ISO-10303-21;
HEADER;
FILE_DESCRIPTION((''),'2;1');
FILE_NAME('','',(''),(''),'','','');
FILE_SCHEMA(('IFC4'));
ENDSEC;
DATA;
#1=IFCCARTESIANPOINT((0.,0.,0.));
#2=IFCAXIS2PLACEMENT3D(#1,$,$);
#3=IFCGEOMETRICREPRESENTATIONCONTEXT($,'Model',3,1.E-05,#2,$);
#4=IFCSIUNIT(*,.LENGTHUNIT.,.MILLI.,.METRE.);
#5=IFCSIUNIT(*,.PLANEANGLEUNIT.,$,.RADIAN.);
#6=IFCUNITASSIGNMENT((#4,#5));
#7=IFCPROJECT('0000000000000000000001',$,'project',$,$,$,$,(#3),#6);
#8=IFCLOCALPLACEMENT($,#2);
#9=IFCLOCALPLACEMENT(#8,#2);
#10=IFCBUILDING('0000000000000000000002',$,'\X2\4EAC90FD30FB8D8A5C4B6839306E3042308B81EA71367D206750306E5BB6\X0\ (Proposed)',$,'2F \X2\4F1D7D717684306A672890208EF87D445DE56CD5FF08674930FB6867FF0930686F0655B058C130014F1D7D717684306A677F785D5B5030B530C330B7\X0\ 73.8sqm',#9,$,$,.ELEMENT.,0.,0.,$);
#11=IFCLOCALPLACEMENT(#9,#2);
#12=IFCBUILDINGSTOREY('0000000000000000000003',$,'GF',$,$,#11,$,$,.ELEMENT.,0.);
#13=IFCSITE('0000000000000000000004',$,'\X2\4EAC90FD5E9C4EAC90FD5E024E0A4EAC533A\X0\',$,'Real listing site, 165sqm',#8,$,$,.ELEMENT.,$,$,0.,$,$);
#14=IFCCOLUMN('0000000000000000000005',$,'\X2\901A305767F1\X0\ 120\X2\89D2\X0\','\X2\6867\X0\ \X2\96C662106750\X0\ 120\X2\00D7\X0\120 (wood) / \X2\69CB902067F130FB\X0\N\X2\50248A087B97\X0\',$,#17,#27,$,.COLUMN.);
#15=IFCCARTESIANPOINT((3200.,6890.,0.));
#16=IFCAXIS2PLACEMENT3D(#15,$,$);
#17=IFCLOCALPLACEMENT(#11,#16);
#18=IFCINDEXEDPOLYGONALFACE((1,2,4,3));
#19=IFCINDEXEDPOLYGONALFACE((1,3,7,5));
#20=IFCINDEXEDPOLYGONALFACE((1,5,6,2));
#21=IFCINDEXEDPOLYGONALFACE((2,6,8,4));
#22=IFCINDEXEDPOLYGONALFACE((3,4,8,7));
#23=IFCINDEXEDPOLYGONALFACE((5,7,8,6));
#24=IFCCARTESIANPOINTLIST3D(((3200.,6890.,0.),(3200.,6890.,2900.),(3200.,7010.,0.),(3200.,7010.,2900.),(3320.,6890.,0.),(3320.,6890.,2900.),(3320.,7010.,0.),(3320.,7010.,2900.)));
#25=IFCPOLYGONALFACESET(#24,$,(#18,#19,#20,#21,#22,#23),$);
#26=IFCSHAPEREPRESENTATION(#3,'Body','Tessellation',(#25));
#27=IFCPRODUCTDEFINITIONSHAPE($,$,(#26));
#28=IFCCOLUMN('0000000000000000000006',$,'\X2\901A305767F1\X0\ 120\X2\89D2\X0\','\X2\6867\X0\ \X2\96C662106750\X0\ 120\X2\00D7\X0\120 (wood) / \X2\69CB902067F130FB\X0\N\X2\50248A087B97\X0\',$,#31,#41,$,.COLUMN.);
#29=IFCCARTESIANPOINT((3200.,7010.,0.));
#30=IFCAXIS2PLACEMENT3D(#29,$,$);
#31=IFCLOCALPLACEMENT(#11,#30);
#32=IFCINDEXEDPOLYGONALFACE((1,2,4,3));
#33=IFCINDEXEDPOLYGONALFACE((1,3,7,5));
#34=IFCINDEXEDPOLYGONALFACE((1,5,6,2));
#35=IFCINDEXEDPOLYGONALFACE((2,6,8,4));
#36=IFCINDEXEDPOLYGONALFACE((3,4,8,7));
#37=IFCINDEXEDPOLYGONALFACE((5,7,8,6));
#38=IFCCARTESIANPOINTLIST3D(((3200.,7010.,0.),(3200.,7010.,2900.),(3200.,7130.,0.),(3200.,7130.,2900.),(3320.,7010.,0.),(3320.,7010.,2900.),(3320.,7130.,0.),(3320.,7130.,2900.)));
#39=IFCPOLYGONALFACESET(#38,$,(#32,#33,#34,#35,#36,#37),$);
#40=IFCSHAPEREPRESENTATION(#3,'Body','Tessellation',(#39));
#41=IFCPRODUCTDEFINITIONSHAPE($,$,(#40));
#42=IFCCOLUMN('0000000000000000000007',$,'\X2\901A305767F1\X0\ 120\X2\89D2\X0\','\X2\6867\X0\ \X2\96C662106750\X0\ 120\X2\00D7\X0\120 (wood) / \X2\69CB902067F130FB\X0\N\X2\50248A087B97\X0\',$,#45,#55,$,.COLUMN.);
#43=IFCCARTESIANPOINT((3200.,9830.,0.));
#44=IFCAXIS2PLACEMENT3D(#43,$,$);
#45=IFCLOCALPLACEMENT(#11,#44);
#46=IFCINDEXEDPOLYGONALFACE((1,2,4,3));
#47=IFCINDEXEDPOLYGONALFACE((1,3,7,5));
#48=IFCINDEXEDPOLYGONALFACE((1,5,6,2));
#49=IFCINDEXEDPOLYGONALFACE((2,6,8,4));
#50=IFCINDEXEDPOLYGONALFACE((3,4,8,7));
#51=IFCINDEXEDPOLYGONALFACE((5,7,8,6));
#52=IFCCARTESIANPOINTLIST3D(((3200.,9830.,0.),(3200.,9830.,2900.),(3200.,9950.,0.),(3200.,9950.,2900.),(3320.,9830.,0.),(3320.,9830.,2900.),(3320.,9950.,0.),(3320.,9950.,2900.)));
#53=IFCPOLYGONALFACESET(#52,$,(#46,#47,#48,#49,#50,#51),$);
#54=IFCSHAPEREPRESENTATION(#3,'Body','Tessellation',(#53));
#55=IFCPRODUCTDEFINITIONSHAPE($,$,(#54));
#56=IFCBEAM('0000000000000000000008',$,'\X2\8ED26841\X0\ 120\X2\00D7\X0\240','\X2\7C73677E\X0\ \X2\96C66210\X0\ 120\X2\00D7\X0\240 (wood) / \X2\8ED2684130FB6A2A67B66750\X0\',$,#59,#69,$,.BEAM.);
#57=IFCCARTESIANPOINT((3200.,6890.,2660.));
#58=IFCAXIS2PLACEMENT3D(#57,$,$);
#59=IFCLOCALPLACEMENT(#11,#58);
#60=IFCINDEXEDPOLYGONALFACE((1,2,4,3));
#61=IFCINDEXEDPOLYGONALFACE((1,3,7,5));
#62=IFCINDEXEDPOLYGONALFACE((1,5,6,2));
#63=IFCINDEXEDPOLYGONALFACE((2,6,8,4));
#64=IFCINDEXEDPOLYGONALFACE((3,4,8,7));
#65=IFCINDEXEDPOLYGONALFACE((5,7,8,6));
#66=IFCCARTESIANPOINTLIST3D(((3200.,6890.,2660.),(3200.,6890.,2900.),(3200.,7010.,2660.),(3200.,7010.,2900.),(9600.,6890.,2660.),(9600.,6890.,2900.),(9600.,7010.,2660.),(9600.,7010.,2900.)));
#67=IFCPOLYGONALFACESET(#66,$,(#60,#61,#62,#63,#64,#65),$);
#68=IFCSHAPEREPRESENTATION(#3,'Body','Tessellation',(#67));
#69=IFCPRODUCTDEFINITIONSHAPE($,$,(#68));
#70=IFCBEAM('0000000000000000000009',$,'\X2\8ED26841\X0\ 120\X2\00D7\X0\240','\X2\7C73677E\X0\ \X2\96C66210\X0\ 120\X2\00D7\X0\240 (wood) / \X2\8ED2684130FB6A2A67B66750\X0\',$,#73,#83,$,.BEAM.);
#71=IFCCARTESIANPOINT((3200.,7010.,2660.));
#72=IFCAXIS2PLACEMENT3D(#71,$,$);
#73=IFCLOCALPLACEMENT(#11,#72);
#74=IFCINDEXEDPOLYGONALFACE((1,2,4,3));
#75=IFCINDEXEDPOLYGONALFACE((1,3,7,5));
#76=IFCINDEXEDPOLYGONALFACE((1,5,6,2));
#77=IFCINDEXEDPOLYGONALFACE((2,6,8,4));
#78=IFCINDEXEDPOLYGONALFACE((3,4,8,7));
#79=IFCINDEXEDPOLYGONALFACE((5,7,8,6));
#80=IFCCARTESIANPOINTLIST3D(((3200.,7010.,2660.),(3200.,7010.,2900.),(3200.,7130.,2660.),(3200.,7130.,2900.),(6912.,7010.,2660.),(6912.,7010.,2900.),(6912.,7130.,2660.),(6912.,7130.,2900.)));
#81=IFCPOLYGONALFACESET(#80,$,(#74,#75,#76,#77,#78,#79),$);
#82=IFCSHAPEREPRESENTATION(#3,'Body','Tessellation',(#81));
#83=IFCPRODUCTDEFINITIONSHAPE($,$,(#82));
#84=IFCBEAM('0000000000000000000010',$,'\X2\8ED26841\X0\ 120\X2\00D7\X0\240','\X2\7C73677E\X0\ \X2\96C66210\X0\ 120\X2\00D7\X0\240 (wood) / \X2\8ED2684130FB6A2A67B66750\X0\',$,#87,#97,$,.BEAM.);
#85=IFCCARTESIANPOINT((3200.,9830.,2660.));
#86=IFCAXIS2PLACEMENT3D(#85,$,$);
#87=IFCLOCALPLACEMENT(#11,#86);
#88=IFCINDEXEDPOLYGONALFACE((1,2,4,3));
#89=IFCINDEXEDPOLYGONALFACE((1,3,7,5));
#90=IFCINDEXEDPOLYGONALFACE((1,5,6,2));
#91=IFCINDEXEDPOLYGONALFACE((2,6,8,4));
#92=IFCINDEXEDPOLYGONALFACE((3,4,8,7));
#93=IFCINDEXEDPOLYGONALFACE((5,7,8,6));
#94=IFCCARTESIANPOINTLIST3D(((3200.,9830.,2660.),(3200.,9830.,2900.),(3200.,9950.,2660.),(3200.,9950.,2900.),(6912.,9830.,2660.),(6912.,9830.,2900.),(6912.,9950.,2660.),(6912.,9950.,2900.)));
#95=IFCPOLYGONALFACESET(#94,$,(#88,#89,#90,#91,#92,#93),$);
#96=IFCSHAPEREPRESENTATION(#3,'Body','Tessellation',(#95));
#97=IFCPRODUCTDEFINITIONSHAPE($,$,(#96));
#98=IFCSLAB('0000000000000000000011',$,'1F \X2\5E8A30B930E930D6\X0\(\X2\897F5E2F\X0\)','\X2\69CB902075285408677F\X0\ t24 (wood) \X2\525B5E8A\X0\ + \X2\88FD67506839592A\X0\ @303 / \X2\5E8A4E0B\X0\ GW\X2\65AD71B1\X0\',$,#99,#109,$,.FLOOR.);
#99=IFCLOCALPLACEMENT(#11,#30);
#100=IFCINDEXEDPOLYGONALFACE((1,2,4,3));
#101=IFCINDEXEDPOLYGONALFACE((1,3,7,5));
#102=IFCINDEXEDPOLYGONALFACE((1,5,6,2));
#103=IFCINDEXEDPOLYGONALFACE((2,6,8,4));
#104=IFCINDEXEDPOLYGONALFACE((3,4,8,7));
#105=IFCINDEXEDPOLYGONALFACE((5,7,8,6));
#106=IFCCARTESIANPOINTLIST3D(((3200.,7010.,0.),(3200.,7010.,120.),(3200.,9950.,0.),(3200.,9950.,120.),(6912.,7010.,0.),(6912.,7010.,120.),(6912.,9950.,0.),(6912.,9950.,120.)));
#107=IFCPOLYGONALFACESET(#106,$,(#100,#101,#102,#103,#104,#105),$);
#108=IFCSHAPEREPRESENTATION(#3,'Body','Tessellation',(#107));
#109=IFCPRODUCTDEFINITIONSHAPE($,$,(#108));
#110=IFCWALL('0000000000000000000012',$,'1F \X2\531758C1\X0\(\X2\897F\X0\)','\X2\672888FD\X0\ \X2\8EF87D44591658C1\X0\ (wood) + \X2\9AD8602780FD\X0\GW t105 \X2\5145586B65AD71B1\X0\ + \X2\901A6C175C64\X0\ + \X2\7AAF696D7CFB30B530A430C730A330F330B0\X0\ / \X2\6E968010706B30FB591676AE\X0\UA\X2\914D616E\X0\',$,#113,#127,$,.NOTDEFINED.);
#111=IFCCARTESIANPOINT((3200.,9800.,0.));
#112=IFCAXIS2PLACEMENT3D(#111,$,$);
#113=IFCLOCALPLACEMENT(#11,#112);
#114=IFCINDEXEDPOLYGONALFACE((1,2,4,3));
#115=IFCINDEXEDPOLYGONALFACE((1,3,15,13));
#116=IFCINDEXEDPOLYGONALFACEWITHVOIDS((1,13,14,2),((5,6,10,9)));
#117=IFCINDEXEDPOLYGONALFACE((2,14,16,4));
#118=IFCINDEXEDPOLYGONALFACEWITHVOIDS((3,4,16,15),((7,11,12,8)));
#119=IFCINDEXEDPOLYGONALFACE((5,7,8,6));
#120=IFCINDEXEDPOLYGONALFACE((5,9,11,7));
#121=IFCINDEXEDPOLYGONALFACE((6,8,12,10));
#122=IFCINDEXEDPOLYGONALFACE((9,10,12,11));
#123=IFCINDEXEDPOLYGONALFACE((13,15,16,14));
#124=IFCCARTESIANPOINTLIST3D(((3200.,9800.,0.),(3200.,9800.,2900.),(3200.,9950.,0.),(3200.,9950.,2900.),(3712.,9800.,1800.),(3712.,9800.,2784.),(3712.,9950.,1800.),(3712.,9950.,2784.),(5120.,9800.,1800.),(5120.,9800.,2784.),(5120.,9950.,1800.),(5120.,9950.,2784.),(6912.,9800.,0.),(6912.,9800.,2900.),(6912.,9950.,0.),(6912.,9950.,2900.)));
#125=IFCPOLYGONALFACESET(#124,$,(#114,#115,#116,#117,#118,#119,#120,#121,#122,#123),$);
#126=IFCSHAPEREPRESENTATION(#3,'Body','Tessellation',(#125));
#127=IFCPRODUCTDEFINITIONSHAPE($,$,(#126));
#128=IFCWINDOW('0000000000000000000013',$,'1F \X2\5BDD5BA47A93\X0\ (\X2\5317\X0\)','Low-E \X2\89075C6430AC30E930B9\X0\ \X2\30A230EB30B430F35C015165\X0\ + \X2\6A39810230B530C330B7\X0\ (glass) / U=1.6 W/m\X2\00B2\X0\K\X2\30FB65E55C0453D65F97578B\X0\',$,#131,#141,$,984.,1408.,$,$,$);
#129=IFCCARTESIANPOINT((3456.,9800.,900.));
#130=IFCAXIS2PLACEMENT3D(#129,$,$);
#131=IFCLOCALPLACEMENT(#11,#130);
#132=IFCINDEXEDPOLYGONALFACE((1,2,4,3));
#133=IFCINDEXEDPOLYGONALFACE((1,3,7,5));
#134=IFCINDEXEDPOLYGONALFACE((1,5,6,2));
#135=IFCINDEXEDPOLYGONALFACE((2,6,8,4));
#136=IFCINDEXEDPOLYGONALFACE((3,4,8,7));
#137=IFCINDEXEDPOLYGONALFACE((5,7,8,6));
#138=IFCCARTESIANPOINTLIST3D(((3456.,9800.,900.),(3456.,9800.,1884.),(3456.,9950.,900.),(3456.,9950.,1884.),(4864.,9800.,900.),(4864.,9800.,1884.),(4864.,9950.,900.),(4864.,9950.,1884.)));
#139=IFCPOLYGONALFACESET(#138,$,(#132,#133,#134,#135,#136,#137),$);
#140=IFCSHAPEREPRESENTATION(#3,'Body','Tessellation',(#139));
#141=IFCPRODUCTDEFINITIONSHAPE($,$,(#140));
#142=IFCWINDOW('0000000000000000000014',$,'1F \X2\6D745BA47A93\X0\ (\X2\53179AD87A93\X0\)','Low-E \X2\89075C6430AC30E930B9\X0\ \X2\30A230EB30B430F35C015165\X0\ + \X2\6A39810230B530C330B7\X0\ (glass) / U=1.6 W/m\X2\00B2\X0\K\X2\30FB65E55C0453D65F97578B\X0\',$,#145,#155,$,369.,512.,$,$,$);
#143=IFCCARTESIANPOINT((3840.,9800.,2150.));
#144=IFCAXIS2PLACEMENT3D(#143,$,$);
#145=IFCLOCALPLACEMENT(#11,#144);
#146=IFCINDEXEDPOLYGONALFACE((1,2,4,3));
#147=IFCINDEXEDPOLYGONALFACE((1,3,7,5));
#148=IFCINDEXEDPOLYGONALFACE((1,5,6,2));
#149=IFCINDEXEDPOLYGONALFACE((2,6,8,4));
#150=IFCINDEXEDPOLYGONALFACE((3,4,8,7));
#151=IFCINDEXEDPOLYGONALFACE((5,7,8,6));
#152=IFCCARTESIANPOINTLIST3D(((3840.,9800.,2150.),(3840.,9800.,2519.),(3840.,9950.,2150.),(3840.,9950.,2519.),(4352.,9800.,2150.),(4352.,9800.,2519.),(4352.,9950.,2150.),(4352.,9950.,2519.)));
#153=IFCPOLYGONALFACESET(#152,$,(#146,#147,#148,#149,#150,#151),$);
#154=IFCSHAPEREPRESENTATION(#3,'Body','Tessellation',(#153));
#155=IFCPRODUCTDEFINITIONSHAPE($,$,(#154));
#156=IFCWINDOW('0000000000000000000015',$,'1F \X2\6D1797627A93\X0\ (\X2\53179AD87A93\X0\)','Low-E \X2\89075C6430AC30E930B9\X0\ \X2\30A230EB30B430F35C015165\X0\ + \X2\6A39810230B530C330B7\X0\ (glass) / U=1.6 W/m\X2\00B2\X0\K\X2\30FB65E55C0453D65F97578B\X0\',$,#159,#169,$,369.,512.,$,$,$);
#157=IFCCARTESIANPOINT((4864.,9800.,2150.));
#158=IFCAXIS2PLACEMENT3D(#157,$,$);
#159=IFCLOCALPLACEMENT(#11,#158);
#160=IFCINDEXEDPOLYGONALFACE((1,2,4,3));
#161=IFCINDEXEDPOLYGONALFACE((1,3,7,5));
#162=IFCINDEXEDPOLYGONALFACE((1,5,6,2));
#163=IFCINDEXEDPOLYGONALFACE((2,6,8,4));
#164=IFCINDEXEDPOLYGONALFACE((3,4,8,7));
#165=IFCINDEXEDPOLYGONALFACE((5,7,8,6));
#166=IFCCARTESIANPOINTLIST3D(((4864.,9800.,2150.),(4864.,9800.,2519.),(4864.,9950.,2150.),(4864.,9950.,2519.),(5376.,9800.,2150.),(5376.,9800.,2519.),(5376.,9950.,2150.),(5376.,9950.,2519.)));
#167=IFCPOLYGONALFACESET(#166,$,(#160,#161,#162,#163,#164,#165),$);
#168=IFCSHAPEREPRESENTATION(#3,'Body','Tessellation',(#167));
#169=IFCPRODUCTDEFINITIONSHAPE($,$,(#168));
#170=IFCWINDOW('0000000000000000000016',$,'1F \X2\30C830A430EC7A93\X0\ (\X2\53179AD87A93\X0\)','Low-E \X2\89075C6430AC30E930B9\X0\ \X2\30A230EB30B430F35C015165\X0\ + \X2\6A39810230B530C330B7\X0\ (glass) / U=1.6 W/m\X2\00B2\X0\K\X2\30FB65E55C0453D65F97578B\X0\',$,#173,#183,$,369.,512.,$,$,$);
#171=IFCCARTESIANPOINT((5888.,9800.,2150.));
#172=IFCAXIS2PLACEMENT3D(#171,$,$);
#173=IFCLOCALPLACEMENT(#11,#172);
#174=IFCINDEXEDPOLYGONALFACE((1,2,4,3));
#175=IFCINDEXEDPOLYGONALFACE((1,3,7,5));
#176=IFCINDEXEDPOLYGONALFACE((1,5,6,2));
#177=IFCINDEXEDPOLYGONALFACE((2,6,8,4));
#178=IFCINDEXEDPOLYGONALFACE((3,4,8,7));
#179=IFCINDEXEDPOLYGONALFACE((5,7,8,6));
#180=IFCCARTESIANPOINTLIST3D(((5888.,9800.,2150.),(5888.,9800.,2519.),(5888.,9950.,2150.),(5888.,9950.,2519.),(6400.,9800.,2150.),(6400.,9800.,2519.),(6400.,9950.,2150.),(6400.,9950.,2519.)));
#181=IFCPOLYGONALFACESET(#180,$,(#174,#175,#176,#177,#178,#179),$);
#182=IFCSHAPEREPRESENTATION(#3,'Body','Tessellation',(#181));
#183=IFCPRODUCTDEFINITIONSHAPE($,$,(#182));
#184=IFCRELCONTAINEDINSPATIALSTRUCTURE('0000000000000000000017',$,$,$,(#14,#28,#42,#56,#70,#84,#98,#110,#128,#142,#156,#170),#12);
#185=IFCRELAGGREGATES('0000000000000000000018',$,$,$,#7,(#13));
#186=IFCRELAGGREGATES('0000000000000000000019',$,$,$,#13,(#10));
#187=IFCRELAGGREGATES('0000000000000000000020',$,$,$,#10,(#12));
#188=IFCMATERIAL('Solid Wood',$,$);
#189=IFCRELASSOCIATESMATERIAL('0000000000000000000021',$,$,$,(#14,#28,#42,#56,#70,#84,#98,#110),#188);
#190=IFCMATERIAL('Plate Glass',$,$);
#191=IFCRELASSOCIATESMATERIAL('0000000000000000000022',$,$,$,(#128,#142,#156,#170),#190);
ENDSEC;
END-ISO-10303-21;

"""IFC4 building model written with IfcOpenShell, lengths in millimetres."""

from ifc_helpers import new_model, si_unit, frame, frame_2d, origin, place, context, project, spatial, rectangle, extrude, material, element, fill, save


model = new_model("IFC4")

# Units and contexts
model_context = context("Model", 3, precision=1e-05, world=origin())
ifc_project = project(units=[si_unit("LENGTHUNIT", "METRE", prefix="MILLI"), si_unit("PLANEANGLEUNIT", "RADIAN")], contexts=[model_context])

# Site, building, storey
site_placement = place(None, origin())
site = spatial("IfcSite", under=ifc_project, at=site_placement, Name="京都府京都市上京区", ObjectType="Real listing site, 165sqm", CompositionType="ELEMENT", RefElevation=0.0)
building_placement = place(site_placement, origin())
building = spatial("IfcBuilding", under=site, at=building_placement, Name="京都・越屋根のある自然素材の家 (Proposed)", ObjectType="2F 伝統的な木造軸組工法（杉・桧）と漆喰壁、伝統的な板硝子サッシ 73.8sqm", CompositionType="ELEMENT", ElevationOfRefHeight=0.0, ElevationOfTerrain=0.0)
storey_placement = place(building_placement, origin())
storey = spatial("IfcBuildingStorey", under=building, at=storey_placement, Name="GF", CompositionType="ELEMENT", Elevation=0.0)

# Columns
ifc_material_1 = material(Name="Solid Wood")
column_1_placement = place(storey_placement, frame((3200.0, 6890.0, 0.0)))
element("IfcColumn", 1, at=column_1_placement, inside=storey, material=ifc_material_1, Name="通し柱 120角", Description="桧 集成材 120×120 (wood) / 構造柱・N値計算", PredefinedType="COLUMN", context=model_context, shape_type="SweptSolid", body=[
    extrude(rectangle(XDim=120.0, YDim=120.0, at=frame_2d((60.0, 60.0))), frame((3200.0, 6890.0, 0.0)), (0.0, 0.0, 1.0), 2900.0),
])
column_2_placement = place(storey_placement, frame((3200.0, 7010.0, 0.0)))
element("IfcColumn", 2, at=column_2_placement, inside=storey, material=ifc_material_1, Name="通し柱 120角", Description="桧 集成材 120×120 (wood) / 構造柱・N値計算", PredefinedType="COLUMN", context=model_context, shape_type="SweptSolid", body=[
    extrude(rectangle(XDim=120.0, YDim=120.0, at=frame_2d((60.0, 60.0))), frame((3200.0, 7010.0, 0.0)), (0.0, 0.0, 1.0), 2900.0),
])
column_3_placement = place(storey_placement, frame((3200.0, 9830.0, 0.0)))
element("IfcColumn", 3, at=column_3_placement, inside=storey, material=ifc_material_1, Name="通し柱 120角", Description="桧 集成材 120×120 (wood) / 構造柱・N値計算", PredefinedType="COLUMN", context=model_context, shape_type="SweptSolid", body=[
    extrude(rectangle(XDim=120.0, YDim=120.0, at=frame_2d((60.0, 60.0))), frame((3200.0, 9830.0, 0.0)), (0.0, 0.0, 1.0), 2900.0),
])

# Beams
beam_1_placement = place(storey_placement, frame((3200.0, 6890.0, 2660.0)))
element("IfcBeam", 4, at=beam_1_placement, inside=storey, material=ifc_material_1, Name="軒桁 120×240", Description="米松 集成 120×240 (wood) / 軒桁・横架材", PredefinedType="BEAM", context=model_context, shape_type="SweptSolid", body=[
    extrude(rectangle(XDim=6400.0, YDim=120.0, at=frame_2d((3200.0, 60.0))), frame((3200.0, 6890.0, 2660.0)), (0.0, 0.0, 1.0), 240.0),
])
beam_2_placement = place(storey_placement, frame((3200.0, 7010.0, 2660.0)))
element("IfcBeam", 5, at=beam_2_placement, inside=storey, material=ifc_material_1, Name="軒桁 120×240", Description="米松 集成 120×240 (wood) / 軒桁・横架材", PredefinedType="BEAM", context=model_context, shape_type="SweptSolid", body=[
    extrude(rectangle(XDim=3712.0, YDim=120.0, at=frame_2d((1856.0, 60.0))), frame((3200.0, 7010.0, 2660.0)), (0.0, 0.0, 1.0), 240.0),
])
beam_3_placement = place(storey_placement, frame((3200.0, 9830.0, 2660.0)))
element("IfcBeam", 6, at=beam_3_placement, inside=storey, material=ifc_material_1, Name="軒桁 120×240", Description="米松 集成 120×240 (wood) / 軒桁・横架材", PredefinedType="BEAM", context=model_context, shape_type="SweptSolid", body=[
    extrude(rectangle(XDim=3712.0, YDim=120.0, at=frame_2d((1856.0, 60.0))), frame((3200.0, 9830.0, 2660.0)), (0.0, 0.0, 1.0), 240.0),
])

# Slab
slab_placement = place(storey_placement, frame((3200.0, 7010.0, 0.0)))
element("IfcSlab", 7, at=slab_placement, inside=storey, material=ifc_material_1, Name="1F 床スラブ(西帯)", Description="構造用合板 t24 (wood) 剛床 + 製材根太 @303 / 床下 GW断熱", PredefinedType="FLOOR", context=model_context, shape_type="SweptSolid", body=[
    extrude(rectangle(XDim=3712.0, YDim=2940.0, at=frame_2d((1856.0, 1470.0))), frame((3200.0, 7010.0, 0.0)), (0.0, 0.0, 1.0), 120.0),
])

# Wall, openings, windows
wall_1_placement = place(storey_placement, frame((3200.0, 9800.0, 0.0)))
wall_1 = element("IfcWall", 8, at=wall_1_placement, inside=storey, material=ifc_material_1, Name="1F 北壁(西)", Description="木製 軸組外壁 (wood) + 高性能GW t105 充填断熱 + 通気層 + 窯業系サイディング / 準耐火・外皮UA配慮", PredefinedType="NOTDEFINED", context=model_context, shape_type="SweptSolid", body=[
    extrude(rectangle(XDim=3712.0, YDim=150.0, at=frame_2d((1856.0, 75.0))), frame((3200.0, 9800.0, 0.0)), (0.0, 0.0, 1.0), 2900.0),
])
opening_1_placement = place(storey_placement, frame((3456.0, 9800.0, 900.0)))
opening_1 = element("IfcOpeningElement", 9, at=opening_1_placement, cuts=wall_1, PredefinedType="NOTDEFINED", context=model_context, shape_type="SweptSolid", body=[
    extrude(rectangle(XDim=1408.0, YDim=150.0, at=frame_2d((704.0, 75.0))), frame((3456.0, 9800.0, 900.0)), (0.0, 0.0, 1.0), 984.0),
])
opening_2_placement = place(storey_placement, frame((3840.0, 9800.0, 2150.0)))
opening_2 = element("IfcOpeningElement", 10, at=opening_2_placement, cuts=wall_1, PredefinedType="NOTDEFINED", context=model_context, shape_type="SweptSolid", body=[
    extrude(rectangle(XDim=512.0, YDim=150.0, at=frame_2d((256.0, 75.0))), frame((3840.0, 9800.0, 2150.0)), (0.0, 0.0, 1.0), 369.0),
])
opening_3_placement = place(storey_placement, frame((4864.0, 9800.0, 2150.0)))
opening_3 = element("IfcOpeningElement", 11, at=opening_3_placement, cuts=wall_1, PredefinedType="NOTDEFINED", context=model_context, shape_type="SweptSolid", body=[
    extrude(rectangle(XDim=512.0, YDim=150.0, at=frame_2d((256.0, 75.0))), frame((4864.0, 9800.0, 2150.0)), (0.0, 0.0, 1.0), 369.0),
])
opening_4_placement = place(storey_placement, frame((5888.0, 9800.0, 2150.0)))
opening_4 = element("IfcOpeningElement", 12, at=opening_4_placement, cuts=wall_1, PredefinedType="NOTDEFINED", context=model_context, shape_type="SweptSolid", body=[
    extrude(rectangle(XDim=512.0, YDim=150.0, at=frame_2d((256.0, 75.0))), frame((5888.0, 9800.0, 2150.0)), (0.0, 0.0, 1.0), 369.0),
])
ifc_material_2 = material(Name="Plate Glass")
window_1_placement = place(storey_placement, frame((3456.0, 9800.0, 900.0)))
window_1 = element("IfcWindow", 13, at=window_1_placement, inside=storey, material=ifc_material_2, Name="1F 寝室窓 (北)", Description="Low-E 複層ガラス アルゴン封入 + 樹脂サッシ (glass) / U=1.6 W/m²K・日射取得型", OverallHeight=984.0, OverallWidth=1408.0, context=model_context, shape_type="SweptSolid", body=[
    extrude(rectangle(XDim=1408.0, YDim=150.0, at=frame_2d((704.0, 75.0))), frame((3456.0, 9800.0, 900.0)), (0.0, 0.0, 1.0), 984.0),
])
fill(opening_1, window_1)
window_2_placement = place(storey_placement, frame((3840.0, 9800.0, 2150.0)))
window_2 = element("IfcWindow", 14, at=window_2_placement, inside=storey, material=ifc_material_2, Name="1F 浴室窓 (北高窓)", Description="Low-E 複層ガラス アルゴン封入 + 樹脂サッシ (glass) / U=1.6 W/m²K・日射取得型", OverallHeight=369.0, OverallWidth=512.0, context=model_context, shape_type="SweptSolid", body=[
    extrude(rectangle(XDim=512.0, YDim=150.0, at=frame_2d((256.0, 75.0))), frame((3840.0, 9800.0, 2150.0)), (0.0, 0.0, 1.0), 369.0),
])
fill(opening_2, window_2)
window_3_placement = place(storey_placement, frame((4864.0, 9800.0, 2150.0)))
window_3 = element("IfcWindow", 15, at=window_3_placement, inside=storey, material=ifc_material_2, Name="1F 洗面窓 (北高窓)", Description="Low-E 複層ガラス アルゴン封入 + 樹脂サッシ (glass) / U=1.6 W/m²K・日射取得型", OverallHeight=369.0, OverallWidth=512.0, context=model_context, shape_type="SweptSolid", body=[
    extrude(rectangle(XDim=512.0, YDim=150.0, at=frame_2d((256.0, 75.0))), frame((4864.0, 9800.0, 2150.0)), (0.0, 0.0, 1.0), 369.0),
])
fill(opening_3, window_3)
window_4_placement = place(storey_placement, frame((5888.0, 9800.0, 2150.0)))
window_4 = element("IfcWindow", 16, at=window_4_placement, inside=storey, material=ifc_material_2, Name="1F トイレ窓 (北高窓)", Description="Low-E 複層ガラス アルゴン封入 + 樹脂サッシ (glass) / U=1.6 W/m²K・日射取得型", OverallHeight=369.0, OverallWidth=512.0, context=model_context, shape_type="SweptSolid", body=[
    extrude(rectangle(XDim=512.0, YDim=150.0, at=frame_2d((256.0, 75.0))), frame((5888.0, 9800.0, 2150.0)), (0.0, 0.0, 1.0), 369.0),
])
fill(opening_4, window_4)

save(model, "model.ifc")
